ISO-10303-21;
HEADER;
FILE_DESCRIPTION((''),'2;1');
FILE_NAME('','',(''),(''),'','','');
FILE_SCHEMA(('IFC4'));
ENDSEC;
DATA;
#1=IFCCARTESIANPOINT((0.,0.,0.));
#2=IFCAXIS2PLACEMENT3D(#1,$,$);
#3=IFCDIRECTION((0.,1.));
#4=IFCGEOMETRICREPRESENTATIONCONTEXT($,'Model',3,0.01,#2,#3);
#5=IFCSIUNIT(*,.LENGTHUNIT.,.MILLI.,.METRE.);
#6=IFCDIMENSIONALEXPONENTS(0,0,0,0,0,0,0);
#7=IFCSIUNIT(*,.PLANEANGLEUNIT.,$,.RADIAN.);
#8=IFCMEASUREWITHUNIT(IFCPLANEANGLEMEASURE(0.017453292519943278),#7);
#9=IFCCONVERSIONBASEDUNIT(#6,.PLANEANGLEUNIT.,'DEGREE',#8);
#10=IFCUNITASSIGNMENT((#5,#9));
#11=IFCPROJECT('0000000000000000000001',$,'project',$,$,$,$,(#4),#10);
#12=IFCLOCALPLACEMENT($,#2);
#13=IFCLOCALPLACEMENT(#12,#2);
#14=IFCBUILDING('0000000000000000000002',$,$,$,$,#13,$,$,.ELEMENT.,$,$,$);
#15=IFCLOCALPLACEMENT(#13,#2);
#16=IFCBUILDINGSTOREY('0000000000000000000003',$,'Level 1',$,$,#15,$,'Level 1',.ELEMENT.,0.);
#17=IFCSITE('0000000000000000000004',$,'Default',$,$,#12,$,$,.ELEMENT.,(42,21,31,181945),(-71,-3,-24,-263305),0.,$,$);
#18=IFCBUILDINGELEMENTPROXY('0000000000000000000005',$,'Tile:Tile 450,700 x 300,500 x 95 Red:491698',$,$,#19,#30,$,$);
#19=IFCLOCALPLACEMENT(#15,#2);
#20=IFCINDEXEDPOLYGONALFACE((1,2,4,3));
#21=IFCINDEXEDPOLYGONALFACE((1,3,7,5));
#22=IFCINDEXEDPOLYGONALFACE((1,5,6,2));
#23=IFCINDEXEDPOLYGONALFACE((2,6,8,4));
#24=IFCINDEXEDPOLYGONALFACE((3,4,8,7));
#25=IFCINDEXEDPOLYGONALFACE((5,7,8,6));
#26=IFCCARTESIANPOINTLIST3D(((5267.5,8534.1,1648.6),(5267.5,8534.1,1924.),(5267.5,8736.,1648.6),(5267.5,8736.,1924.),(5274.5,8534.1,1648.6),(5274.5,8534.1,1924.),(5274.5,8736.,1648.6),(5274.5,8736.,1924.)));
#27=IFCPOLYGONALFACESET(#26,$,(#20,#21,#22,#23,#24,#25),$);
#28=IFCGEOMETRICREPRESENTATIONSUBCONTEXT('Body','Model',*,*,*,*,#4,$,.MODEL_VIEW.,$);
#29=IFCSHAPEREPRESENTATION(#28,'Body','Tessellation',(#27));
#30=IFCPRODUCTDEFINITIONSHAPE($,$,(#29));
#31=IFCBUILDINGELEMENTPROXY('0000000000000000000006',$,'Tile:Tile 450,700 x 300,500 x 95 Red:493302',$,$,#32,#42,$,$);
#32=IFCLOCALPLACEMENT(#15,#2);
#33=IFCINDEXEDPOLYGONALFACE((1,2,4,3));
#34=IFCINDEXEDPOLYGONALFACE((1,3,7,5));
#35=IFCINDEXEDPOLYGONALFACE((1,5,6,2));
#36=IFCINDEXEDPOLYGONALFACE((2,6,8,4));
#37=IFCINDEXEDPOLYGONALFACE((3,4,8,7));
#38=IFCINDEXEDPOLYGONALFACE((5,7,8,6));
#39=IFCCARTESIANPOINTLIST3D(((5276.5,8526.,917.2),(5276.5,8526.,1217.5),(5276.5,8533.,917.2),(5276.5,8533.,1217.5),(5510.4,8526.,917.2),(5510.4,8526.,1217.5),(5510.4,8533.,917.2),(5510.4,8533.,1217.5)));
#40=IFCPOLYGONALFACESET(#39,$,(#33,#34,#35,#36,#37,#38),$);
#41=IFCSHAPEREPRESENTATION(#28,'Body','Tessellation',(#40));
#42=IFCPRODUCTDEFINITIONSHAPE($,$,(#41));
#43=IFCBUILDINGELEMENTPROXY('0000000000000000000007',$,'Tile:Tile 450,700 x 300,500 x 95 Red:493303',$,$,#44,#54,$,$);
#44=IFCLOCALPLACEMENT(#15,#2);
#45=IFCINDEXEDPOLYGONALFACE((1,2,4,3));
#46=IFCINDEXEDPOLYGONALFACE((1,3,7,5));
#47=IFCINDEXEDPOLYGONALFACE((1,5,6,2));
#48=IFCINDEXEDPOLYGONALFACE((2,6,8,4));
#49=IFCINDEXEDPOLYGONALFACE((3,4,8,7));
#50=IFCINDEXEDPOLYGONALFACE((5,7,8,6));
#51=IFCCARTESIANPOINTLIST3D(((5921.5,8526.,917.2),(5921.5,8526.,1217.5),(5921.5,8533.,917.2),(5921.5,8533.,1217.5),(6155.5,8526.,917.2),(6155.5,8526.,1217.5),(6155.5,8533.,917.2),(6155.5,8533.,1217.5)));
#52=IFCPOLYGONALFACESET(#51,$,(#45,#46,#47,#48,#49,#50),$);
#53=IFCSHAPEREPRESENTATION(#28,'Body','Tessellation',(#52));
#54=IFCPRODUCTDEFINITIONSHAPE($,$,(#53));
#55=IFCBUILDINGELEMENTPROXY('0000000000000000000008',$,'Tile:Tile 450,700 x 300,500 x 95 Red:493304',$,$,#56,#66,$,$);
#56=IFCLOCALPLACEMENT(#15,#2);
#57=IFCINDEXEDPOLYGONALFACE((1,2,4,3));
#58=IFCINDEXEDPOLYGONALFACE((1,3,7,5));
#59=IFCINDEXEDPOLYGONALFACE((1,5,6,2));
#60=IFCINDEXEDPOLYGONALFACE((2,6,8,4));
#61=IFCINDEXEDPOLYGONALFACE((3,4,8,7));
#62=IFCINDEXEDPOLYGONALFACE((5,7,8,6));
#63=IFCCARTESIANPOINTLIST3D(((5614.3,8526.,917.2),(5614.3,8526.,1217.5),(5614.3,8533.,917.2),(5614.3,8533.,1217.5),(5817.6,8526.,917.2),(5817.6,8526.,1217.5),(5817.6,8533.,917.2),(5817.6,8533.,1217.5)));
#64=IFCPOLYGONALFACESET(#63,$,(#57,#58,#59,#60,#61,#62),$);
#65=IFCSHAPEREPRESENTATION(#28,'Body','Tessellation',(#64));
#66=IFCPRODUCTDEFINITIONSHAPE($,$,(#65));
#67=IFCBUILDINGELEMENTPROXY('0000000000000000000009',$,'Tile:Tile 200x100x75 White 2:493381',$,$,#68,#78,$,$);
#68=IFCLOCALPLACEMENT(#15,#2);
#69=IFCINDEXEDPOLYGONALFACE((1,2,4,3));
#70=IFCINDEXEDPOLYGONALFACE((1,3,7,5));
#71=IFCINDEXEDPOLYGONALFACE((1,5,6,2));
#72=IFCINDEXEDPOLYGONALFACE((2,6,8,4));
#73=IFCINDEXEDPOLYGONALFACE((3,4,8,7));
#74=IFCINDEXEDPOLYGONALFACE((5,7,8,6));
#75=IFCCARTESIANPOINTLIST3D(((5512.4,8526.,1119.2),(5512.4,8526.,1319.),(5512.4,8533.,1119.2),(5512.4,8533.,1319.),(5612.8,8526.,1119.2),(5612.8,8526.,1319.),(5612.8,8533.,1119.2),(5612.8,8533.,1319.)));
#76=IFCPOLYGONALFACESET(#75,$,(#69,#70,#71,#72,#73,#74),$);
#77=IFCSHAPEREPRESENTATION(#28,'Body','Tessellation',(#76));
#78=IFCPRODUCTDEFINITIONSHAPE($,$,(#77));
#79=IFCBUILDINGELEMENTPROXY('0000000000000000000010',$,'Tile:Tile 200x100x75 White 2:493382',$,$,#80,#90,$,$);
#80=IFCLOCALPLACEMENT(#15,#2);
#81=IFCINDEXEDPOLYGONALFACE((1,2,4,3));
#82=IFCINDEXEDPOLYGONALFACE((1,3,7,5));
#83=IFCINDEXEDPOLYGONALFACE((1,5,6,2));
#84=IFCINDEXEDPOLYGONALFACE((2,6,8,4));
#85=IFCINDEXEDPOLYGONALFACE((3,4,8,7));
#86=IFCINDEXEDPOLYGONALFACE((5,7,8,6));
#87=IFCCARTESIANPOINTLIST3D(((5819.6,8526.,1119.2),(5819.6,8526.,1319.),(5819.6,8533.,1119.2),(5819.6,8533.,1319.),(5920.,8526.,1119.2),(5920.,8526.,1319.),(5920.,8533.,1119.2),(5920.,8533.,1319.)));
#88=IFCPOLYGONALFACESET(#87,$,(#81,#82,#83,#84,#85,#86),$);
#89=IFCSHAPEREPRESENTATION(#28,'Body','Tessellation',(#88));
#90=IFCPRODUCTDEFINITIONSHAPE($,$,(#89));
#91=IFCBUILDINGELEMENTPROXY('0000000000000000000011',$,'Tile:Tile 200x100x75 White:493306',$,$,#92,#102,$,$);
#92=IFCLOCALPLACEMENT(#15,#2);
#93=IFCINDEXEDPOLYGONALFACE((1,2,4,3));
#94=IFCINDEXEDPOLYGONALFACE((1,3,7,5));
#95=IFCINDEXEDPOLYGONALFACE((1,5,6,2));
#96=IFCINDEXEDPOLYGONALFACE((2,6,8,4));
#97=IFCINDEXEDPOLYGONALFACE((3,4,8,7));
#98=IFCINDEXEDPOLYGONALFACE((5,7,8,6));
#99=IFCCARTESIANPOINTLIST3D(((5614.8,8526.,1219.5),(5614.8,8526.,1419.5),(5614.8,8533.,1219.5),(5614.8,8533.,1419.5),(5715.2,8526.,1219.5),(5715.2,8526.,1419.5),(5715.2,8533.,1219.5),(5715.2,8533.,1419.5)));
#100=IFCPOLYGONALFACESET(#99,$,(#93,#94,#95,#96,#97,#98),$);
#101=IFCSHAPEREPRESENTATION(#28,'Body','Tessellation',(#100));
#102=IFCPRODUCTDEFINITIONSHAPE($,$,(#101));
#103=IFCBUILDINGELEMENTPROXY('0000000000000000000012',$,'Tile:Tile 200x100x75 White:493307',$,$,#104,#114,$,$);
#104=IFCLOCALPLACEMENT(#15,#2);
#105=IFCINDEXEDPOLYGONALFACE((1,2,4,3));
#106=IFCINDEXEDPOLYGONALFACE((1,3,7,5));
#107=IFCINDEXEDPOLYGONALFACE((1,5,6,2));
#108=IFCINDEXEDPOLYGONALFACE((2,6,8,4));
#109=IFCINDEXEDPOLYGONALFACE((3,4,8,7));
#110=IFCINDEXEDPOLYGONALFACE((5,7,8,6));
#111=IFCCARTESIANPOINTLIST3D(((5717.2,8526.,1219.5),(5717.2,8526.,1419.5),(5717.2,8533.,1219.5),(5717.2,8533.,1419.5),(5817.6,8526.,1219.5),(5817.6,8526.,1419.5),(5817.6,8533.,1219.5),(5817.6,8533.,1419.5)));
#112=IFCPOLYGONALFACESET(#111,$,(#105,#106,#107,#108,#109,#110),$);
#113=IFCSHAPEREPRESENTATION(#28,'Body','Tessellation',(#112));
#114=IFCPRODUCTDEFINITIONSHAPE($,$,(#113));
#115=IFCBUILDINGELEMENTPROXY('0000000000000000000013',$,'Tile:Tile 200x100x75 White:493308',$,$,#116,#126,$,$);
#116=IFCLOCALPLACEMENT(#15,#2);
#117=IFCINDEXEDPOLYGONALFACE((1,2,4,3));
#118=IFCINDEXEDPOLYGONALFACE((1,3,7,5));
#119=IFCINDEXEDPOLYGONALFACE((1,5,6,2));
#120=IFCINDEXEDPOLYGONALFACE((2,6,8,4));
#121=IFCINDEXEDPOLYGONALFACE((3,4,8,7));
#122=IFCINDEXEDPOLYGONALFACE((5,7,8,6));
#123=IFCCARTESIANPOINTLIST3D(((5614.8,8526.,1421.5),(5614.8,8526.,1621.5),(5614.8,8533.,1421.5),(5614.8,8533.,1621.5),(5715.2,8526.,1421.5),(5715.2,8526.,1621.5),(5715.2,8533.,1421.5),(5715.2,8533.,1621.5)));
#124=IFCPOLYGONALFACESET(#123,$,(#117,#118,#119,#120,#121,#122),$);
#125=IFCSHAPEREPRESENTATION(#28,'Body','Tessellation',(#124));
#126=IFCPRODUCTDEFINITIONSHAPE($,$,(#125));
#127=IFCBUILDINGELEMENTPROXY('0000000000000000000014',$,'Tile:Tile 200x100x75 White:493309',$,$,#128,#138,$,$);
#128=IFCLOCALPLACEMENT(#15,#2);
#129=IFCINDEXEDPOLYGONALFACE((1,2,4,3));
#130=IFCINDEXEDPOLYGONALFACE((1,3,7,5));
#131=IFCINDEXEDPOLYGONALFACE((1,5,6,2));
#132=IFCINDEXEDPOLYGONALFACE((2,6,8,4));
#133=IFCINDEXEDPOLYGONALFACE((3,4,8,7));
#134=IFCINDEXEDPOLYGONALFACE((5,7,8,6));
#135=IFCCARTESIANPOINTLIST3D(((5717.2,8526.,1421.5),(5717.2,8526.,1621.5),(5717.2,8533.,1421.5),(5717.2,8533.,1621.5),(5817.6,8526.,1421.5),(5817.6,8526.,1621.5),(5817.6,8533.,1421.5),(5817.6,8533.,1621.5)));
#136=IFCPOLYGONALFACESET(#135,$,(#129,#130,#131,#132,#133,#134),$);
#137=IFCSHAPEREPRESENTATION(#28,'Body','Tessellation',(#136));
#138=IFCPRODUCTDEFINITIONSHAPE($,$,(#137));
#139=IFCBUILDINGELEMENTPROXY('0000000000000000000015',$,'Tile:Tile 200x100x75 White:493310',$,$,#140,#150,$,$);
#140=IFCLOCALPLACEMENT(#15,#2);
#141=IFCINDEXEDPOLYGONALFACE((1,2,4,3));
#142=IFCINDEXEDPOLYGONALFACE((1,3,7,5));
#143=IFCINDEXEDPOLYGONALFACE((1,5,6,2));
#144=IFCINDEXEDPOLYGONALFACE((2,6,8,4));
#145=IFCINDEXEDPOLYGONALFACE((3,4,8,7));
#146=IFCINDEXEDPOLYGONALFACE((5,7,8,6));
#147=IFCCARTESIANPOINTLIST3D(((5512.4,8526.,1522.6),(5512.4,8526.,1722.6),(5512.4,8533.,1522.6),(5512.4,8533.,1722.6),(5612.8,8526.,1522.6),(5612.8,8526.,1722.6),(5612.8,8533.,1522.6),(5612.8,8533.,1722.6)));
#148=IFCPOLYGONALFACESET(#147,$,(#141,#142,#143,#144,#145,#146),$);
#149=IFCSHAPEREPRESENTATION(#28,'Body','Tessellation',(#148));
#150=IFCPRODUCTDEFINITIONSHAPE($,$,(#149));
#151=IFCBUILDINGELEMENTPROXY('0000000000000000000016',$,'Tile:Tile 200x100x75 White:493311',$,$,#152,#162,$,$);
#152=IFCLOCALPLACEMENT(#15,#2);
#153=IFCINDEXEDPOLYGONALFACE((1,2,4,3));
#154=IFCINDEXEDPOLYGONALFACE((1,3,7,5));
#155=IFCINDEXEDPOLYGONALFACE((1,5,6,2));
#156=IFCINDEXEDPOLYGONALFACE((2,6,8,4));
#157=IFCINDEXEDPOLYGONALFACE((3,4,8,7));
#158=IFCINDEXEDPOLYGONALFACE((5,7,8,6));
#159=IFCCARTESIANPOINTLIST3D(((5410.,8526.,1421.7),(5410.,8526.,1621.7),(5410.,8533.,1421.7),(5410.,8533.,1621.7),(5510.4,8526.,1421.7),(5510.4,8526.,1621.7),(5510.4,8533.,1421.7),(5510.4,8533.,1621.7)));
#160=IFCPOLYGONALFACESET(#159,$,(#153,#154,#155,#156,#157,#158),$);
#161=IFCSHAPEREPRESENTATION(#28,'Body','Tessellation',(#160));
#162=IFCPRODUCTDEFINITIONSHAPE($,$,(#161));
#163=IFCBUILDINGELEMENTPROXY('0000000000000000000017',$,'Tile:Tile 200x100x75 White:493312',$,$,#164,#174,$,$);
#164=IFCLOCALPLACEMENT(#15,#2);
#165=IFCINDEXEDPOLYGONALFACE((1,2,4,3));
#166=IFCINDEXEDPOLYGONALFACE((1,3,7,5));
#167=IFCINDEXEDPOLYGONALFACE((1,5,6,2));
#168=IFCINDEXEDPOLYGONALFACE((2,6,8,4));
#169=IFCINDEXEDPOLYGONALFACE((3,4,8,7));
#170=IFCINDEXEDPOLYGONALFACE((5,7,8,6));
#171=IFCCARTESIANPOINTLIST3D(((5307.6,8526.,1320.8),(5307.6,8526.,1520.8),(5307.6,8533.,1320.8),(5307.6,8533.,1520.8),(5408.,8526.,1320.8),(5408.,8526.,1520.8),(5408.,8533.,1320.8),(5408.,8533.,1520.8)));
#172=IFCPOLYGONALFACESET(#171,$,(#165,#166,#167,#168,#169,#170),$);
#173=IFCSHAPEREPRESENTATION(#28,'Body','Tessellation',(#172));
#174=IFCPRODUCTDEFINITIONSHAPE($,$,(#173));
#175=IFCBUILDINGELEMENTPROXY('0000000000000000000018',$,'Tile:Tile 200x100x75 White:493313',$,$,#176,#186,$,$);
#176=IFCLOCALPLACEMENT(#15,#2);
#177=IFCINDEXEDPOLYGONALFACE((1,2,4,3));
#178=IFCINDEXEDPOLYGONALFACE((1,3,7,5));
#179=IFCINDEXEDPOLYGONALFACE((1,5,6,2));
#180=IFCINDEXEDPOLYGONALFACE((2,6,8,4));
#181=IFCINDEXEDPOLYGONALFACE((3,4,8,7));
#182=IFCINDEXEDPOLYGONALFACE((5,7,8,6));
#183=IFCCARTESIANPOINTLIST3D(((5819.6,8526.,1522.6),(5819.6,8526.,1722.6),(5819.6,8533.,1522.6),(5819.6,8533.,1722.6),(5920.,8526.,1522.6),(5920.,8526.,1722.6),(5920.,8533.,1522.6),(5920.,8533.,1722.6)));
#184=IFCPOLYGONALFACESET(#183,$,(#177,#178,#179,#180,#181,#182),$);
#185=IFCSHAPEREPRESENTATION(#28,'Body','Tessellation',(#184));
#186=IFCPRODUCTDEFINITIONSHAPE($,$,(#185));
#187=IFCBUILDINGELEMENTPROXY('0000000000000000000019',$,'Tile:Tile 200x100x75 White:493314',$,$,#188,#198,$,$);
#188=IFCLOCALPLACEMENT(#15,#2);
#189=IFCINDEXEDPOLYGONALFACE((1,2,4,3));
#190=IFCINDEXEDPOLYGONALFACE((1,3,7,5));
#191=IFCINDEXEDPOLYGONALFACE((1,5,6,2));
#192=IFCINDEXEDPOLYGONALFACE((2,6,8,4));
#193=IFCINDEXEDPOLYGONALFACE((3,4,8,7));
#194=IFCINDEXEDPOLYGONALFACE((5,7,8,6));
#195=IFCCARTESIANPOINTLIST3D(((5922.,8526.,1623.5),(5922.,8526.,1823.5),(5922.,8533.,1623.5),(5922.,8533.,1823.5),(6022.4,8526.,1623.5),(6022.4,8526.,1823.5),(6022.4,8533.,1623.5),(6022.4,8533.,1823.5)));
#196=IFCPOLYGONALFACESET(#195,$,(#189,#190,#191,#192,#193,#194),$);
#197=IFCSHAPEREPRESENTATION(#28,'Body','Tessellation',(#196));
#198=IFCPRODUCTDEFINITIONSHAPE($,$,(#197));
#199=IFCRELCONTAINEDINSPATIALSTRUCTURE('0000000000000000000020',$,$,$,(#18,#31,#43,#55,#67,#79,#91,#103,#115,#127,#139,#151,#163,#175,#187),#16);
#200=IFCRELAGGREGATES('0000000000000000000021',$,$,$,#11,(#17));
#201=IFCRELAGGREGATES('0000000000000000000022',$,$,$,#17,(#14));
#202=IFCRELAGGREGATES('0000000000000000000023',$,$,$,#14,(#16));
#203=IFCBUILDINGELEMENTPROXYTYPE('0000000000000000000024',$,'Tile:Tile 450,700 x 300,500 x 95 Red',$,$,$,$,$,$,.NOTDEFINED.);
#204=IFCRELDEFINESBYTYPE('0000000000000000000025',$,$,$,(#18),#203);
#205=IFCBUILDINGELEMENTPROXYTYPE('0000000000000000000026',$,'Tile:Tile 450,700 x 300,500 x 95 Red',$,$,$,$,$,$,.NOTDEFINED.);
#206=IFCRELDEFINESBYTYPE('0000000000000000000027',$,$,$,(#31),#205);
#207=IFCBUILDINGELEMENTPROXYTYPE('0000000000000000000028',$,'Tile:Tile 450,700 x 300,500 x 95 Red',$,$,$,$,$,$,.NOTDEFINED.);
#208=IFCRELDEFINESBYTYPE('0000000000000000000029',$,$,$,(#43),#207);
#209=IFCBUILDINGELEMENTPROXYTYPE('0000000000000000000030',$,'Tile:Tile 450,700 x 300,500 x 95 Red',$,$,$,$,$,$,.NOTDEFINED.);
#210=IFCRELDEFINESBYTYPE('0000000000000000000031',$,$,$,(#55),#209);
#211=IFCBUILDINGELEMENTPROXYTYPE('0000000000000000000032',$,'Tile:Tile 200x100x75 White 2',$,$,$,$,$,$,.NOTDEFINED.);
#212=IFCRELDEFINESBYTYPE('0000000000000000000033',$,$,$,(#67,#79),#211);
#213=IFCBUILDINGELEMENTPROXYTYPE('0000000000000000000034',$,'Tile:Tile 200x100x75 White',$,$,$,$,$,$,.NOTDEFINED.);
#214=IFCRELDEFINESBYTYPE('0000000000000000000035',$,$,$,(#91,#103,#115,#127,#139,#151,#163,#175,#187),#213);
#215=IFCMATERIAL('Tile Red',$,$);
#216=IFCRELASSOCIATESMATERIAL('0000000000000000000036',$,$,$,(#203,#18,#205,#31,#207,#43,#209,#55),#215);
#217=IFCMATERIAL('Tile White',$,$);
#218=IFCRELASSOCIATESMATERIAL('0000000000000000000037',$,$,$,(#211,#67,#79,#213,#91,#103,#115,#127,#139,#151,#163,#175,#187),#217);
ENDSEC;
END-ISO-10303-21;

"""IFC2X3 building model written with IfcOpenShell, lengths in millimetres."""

from ifc_helpers import new_model, entity, si_unit, converted_unit, direction, frame, frame_2d, origin, place, context, subcontext, project, spatial, rectangle, extrude, source, transform, mapped, material, type_object, type_shapes, element, save


model = new_model("IFC2X3")

# Units and contexts
model_context = context("Model", 3, precision=0.01, world=origin(), true_north=direction((0.0, 1.0)))
body_context = subcontext(model_context, "Body", "Model", "MODEL_VIEW")
ifc_project = project(units=[si_unit("LENGTHUNIT", "METRE", prefix="MILLI"), converted_unit("PLANEANGLEUNIT", "DEGREE", entity("IfcPlaneAngleMeasure", 0.017453292519943278), si_unit("PLANEANGLEUNIT", "RADIAN"), dimensions=[0, 0, 0, 0, 0, 0, 0])], contexts=[model_context])

# Site, building, storey
site_placement = place(None, origin())
site = spatial("IfcSite", under=ifc_project, at=site_placement, Name="Default", CompositionType="ELEMENT", RefLatitude=(42, 21, 31, 181945), RefLongitude=(-71, -3, -24, -263305), RefElevation=0.0)
building_placement = place(site_placement, origin())
building = spatial("IfcBuilding", under=site, at=building_placement, CompositionType="ELEMENT")
storey_placement = place(building_placement, origin())
storey = spatial("IfcBuildingStorey", under=building, at=storey_placement, Name="Level 1", LongName="Level 1", CompositionType="ELEMENT", Elevation=0.0)

# Building element proxies
ifc_material_1 = material(Name="Tile Red")
building_element_proxy_type_1 = type_object("IfcBuildingElementProxyType", Name="Tile:Tile 450,700 x 300,500 x 95 Red", PredefinedType="NOTDEFINED", material=ifc_material_1)
shared_shape_1 = source(origin(), body_context, "Body", "SweptSolid", [
    extrude(rectangle(XDim=202.0, YDim=275.4, at=frame_2d((0.0, 0.0), x_axis=(1.0, 0.0))), frame((-101.0, -137.7, 0.0), z_axis=(0.0, 0.0, 1.0), x_axis=(-1.0, 0.0, 0.0)), (0.0, 0.0, 1.0), 7.0),
])
type_shapes(building_element_proxy_type_1, [shared_shape_1])
proxy_1_placement = place(storey_placement, frame((5274.5, 8736.0, 1648.6), z_axis=(-1.0, 0.0, 0.0), x_axis=(0.0, 1.0, 0.0)))
element("IfcBuildingElementProxy", 1, at=proxy_1_placement, inside=storey, type_object=building_element_proxy_type_1, material=ifc_material_1, Name="Tile:Tile 450,700 x 300,500 x 95 Red:491698", context=body_context, shape_type="MappedRepresentation", body=[
    mapped(shared_shape_1, transform((0.0, 0.0, 0.0), scale=1.0)),
])
building_element_proxy_type_2 = type_object("IfcBuildingElementProxyType", Name="Tile:Tile 450,700 x 300,500 x 95 Red", PredefinedType="NOTDEFINED", material=ifc_material_1)
shared_shape_2 = source(origin(), body_context, "Body", "SweptSolid", [
    extrude(rectangle(XDim=233.9, YDim=300.3, at=frame_2d((0.0, 0.0), x_axis=(1.0, 0.0))), frame((-116.9, -150.2, 0.0), z_axis=(0.0, 0.0, 1.0), x_axis=(-1.0, 0.0, 0.0)), (0.0, 0.0, 1.0), 7.0),
])
type_shapes(building_element_proxy_type_2, [shared_shape_2])
proxy_2_placement = place(storey_placement, frame((5510.4, 8533.0, 1217.5), z_axis=(0.0, -1.0, 0.0), x_axis=(1.0, 0.0, 0.0)))
element("IfcBuildingElementProxy", 2, at=proxy_2_placement, inside=storey, type_object=building_element_proxy_type_2, material=ifc_material_1, Name="Tile:Tile 450,700 x 300,500 x 95 Red:493302", context=body_context, shape_type="MappedRepresentation", body=[
    mapped(shared_shape_2, transform((0.0, 0.0, 0.0), scale=1.0)),
])
building_element_proxy_type_3 = type_object("IfcBuildingElementProxyType", Name="Tile:Tile 450,700 x 300,500 x 95 Red", PredefinedType="NOTDEFINED", material=ifc_material_1)
shared_shape_3 = source(origin(), body_context, "Body", "SweptSolid", [
    extrude(rectangle(XDim=233.9, YDim=300.3, at=frame_2d((0.0, 0.0), x_axis=(1.0, 0.0))), frame((-117.0, -150.2, 0.0), z_axis=(0.0, 0.0, 1.0), x_axis=(-1.0, 0.0, 0.0)), (0.0, 0.0, 1.0), 7.0),
])
type_shapes(building_element_proxy_type_3, [shared_shape_3])
proxy_3_placement = place(storey_placement, frame((6155.5, 8533.0, 1217.5), z_axis=(0.0, -1.0, 0.0), x_axis=(1.0, 0.0, 0.0)))
element("IfcBuildingElementProxy", 3, at=proxy_3_placement, inside=storey, type_object=building_element_proxy_type_3, material=ifc_material_1, Name="Tile:Tile 450,700 x 300,500 x 95 Red:493303", context=body_context, shape_type="MappedRepresentation", body=[
    mapped(shared_shape_3, transform((0.0, 0.0, 0.0), scale=1.0)),
])
building_element_proxy_type_4 = type_object("IfcBuildingElementProxyType", Name="Tile:Tile 450,700 x 300,500 x 95 Red", PredefinedType="NOTDEFINED", material=ifc_material_1)
shared_shape_4 = source(origin(), body_context, "Body", "SweptSolid", [
    extrude(rectangle(XDim=203.3, YDim=300.3, at=frame_2d((0.0, 0.0), x_axis=(1.0, 0.0))), frame((-101.6, -150.2, 0.0), z_axis=(0.0, 0.0, 1.0), x_axis=(-1.0, 0.0, 0.0)), (0.0, 0.0, 1.0), 7.0),
])
type_shapes(building_element_proxy_type_4, [shared_shape_4])
proxy_4_placement = place(storey_placement, frame((5817.6, 8533.0, 1217.5), z_axis=(0.0, -1.0, 0.0), x_axis=(1.0, 0.0, 0.0)))
element("IfcBuildingElementProxy", 4, at=proxy_4_placement, inside=storey, type_object=building_element_proxy_type_4, material=ifc_material_1, Name="Tile:Tile 450,700 x 300,500 x 95 Red:493304", context=body_context, shape_type="MappedRepresentation", body=[
    mapped(shared_shape_4, transform((0.0, 0.0, 0.0), scale=1.0)),
])
ifc_material_2 = material(Name="Tile White")
building_element_proxy_type_5 = type_object("IfcBuildingElementProxyType", Name="Tile:Tile 200x100x75 White 2", PredefinedType="NOTDEFINED", material=ifc_material_2)
shared_shape_5 = source(origin(), body_context, "Body", "SweptSolid", [
    extrude(rectangle(XDim=199.8, YDim=100.4, at=frame_2d((0.0, 0.0), x_axis=(1.0, 0.0))), frame((-50.2, -99.9, 0.0), z_axis=(0.0, 0.0, 1.0), x_axis=(0.0, -1.0, 0.0)), (0.0, 0.0, 1.0), 7.0),
])
type_shapes(building_element_proxy_type_5, [shared_shape_5])
for number, where, z_axis, x_axis, name in (
    (5, (5612.8, 8533.0, 1319.0), (0.0, -1.0, 0.0), (1.0, 0.0, 0.0), "Tile:Tile 200x100x75 White 2:493381"),
    (6, (5920.0, 8533.0, 1319.0), (0.0, -1.0, 0.0), (1.0, 0.0, 0.0), "Tile:Tile 200x100x75 White 2:493382"),
):
    element("IfcBuildingElementProxy", number, at=place(storey_placement, frame(where, z_axis=z_axis, x_axis=x_axis)), inside=storey, type_object=building_element_proxy_type_5, material=ifc_material_2, Name=name, context=body_context, shape_type="MappedRepresentation", body=[
        mapped(shared_shape_5, transform((0.0, 0.0, 0.0), scale=1.0)),
    ])
building_element_proxy_type_6 = type_object("IfcBuildingElementProxyType", Name="Tile:Tile 200x100x75 White", PredefinedType="NOTDEFINED", material=ifc_material_2)
shared_shape_6 = source(origin(), body_context, "Body", "SweptSolid", [
    extrude(rectangle(XDim=200.0, YDim=100.4, at=frame_2d((0.0, 0.0), x_axis=(1.0, 0.0))), frame((-50.2, -100.0, 0.0), z_axis=(0.0, 0.0, 1.0), x_axis=(0.0, -1.0, 0.0)), (0.0, 0.0, 1.0), 7.0),
])
type_shapes(building_element_proxy_type_6, [shared_shape_6])
for number, where, z_axis, x_axis, name in (
    (7, (5715.2, 8533.0, 1419.5), (0.0, -1.0, 0.0), (1.0, 0.0, 0.0), "Tile:Tile 200x100x75 White:493306"),
    (8, (5817.6, 8533.0, 1419.5), (0.0, -1.0, 0.0), (1.0, 0.0, 0.0), "Tile:Tile 200x100x75 White:493307"),
    (9, (5715.2, 8533.0, 1621.5), (0.0, -1.0, 0.0), (1.0, 0.0, 0.0), "Tile:Tile 200x100x75 White:493308"),
    (10, (5817.6, 8533.0, 1621.5), (0.0, -1.0, 0.0), (1.0, 0.0, 0.0), "Tile:Tile 200x100x75 White:493309"),
    (11, (5612.8, 8533.0, 1722.6), (0.0, -1.0, 0.0), (1.0, 0.0, 0.0), "Tile:Tile 200x100x75 White:493310"),
    (12, (5510.4, 8533.0, 1621.7), (0.0, -1.0, 0.0), (1.0, 0.0, 0.0), "Tile:Tile 200x100x75 White:493311"),
    (13, (5408.0, 8533.0, 1520.8), (0.0, -1.0, 0.0), (1.0, 0.0, 0.0), "Tile:Tile 200x100x75 White:493312"),
    (14, (5819.6, 8533.0, 1522.6), (0.0, -1.0, 0.0), (-1.0, 0.0, 0.0), "Tile:Tile 200x100x75 White:493313"),
    (15, (5922.0, 8533.0, 1623.5), (0.0, -1.0, 0.0), (-1.0, 0.0, 0.0), "Tile:Tile 200x100x75 White:493314"),
):
    element("IfcBuildingElementProxy", number, at=place(storey_placement, frame(where, z_axis=z_axis, x_axis=x_axis)), inside=storey, type_object=building_element_proxy_type_6, material=ifc_material_2, Name=name, context=body_context, shape_type="MappedRepresentation", body=[
        mapped(shared_shape_6, transform((0.0, 0.0, 0.0), scale=1.0)),
    ])

save(model, "model.ifc")
